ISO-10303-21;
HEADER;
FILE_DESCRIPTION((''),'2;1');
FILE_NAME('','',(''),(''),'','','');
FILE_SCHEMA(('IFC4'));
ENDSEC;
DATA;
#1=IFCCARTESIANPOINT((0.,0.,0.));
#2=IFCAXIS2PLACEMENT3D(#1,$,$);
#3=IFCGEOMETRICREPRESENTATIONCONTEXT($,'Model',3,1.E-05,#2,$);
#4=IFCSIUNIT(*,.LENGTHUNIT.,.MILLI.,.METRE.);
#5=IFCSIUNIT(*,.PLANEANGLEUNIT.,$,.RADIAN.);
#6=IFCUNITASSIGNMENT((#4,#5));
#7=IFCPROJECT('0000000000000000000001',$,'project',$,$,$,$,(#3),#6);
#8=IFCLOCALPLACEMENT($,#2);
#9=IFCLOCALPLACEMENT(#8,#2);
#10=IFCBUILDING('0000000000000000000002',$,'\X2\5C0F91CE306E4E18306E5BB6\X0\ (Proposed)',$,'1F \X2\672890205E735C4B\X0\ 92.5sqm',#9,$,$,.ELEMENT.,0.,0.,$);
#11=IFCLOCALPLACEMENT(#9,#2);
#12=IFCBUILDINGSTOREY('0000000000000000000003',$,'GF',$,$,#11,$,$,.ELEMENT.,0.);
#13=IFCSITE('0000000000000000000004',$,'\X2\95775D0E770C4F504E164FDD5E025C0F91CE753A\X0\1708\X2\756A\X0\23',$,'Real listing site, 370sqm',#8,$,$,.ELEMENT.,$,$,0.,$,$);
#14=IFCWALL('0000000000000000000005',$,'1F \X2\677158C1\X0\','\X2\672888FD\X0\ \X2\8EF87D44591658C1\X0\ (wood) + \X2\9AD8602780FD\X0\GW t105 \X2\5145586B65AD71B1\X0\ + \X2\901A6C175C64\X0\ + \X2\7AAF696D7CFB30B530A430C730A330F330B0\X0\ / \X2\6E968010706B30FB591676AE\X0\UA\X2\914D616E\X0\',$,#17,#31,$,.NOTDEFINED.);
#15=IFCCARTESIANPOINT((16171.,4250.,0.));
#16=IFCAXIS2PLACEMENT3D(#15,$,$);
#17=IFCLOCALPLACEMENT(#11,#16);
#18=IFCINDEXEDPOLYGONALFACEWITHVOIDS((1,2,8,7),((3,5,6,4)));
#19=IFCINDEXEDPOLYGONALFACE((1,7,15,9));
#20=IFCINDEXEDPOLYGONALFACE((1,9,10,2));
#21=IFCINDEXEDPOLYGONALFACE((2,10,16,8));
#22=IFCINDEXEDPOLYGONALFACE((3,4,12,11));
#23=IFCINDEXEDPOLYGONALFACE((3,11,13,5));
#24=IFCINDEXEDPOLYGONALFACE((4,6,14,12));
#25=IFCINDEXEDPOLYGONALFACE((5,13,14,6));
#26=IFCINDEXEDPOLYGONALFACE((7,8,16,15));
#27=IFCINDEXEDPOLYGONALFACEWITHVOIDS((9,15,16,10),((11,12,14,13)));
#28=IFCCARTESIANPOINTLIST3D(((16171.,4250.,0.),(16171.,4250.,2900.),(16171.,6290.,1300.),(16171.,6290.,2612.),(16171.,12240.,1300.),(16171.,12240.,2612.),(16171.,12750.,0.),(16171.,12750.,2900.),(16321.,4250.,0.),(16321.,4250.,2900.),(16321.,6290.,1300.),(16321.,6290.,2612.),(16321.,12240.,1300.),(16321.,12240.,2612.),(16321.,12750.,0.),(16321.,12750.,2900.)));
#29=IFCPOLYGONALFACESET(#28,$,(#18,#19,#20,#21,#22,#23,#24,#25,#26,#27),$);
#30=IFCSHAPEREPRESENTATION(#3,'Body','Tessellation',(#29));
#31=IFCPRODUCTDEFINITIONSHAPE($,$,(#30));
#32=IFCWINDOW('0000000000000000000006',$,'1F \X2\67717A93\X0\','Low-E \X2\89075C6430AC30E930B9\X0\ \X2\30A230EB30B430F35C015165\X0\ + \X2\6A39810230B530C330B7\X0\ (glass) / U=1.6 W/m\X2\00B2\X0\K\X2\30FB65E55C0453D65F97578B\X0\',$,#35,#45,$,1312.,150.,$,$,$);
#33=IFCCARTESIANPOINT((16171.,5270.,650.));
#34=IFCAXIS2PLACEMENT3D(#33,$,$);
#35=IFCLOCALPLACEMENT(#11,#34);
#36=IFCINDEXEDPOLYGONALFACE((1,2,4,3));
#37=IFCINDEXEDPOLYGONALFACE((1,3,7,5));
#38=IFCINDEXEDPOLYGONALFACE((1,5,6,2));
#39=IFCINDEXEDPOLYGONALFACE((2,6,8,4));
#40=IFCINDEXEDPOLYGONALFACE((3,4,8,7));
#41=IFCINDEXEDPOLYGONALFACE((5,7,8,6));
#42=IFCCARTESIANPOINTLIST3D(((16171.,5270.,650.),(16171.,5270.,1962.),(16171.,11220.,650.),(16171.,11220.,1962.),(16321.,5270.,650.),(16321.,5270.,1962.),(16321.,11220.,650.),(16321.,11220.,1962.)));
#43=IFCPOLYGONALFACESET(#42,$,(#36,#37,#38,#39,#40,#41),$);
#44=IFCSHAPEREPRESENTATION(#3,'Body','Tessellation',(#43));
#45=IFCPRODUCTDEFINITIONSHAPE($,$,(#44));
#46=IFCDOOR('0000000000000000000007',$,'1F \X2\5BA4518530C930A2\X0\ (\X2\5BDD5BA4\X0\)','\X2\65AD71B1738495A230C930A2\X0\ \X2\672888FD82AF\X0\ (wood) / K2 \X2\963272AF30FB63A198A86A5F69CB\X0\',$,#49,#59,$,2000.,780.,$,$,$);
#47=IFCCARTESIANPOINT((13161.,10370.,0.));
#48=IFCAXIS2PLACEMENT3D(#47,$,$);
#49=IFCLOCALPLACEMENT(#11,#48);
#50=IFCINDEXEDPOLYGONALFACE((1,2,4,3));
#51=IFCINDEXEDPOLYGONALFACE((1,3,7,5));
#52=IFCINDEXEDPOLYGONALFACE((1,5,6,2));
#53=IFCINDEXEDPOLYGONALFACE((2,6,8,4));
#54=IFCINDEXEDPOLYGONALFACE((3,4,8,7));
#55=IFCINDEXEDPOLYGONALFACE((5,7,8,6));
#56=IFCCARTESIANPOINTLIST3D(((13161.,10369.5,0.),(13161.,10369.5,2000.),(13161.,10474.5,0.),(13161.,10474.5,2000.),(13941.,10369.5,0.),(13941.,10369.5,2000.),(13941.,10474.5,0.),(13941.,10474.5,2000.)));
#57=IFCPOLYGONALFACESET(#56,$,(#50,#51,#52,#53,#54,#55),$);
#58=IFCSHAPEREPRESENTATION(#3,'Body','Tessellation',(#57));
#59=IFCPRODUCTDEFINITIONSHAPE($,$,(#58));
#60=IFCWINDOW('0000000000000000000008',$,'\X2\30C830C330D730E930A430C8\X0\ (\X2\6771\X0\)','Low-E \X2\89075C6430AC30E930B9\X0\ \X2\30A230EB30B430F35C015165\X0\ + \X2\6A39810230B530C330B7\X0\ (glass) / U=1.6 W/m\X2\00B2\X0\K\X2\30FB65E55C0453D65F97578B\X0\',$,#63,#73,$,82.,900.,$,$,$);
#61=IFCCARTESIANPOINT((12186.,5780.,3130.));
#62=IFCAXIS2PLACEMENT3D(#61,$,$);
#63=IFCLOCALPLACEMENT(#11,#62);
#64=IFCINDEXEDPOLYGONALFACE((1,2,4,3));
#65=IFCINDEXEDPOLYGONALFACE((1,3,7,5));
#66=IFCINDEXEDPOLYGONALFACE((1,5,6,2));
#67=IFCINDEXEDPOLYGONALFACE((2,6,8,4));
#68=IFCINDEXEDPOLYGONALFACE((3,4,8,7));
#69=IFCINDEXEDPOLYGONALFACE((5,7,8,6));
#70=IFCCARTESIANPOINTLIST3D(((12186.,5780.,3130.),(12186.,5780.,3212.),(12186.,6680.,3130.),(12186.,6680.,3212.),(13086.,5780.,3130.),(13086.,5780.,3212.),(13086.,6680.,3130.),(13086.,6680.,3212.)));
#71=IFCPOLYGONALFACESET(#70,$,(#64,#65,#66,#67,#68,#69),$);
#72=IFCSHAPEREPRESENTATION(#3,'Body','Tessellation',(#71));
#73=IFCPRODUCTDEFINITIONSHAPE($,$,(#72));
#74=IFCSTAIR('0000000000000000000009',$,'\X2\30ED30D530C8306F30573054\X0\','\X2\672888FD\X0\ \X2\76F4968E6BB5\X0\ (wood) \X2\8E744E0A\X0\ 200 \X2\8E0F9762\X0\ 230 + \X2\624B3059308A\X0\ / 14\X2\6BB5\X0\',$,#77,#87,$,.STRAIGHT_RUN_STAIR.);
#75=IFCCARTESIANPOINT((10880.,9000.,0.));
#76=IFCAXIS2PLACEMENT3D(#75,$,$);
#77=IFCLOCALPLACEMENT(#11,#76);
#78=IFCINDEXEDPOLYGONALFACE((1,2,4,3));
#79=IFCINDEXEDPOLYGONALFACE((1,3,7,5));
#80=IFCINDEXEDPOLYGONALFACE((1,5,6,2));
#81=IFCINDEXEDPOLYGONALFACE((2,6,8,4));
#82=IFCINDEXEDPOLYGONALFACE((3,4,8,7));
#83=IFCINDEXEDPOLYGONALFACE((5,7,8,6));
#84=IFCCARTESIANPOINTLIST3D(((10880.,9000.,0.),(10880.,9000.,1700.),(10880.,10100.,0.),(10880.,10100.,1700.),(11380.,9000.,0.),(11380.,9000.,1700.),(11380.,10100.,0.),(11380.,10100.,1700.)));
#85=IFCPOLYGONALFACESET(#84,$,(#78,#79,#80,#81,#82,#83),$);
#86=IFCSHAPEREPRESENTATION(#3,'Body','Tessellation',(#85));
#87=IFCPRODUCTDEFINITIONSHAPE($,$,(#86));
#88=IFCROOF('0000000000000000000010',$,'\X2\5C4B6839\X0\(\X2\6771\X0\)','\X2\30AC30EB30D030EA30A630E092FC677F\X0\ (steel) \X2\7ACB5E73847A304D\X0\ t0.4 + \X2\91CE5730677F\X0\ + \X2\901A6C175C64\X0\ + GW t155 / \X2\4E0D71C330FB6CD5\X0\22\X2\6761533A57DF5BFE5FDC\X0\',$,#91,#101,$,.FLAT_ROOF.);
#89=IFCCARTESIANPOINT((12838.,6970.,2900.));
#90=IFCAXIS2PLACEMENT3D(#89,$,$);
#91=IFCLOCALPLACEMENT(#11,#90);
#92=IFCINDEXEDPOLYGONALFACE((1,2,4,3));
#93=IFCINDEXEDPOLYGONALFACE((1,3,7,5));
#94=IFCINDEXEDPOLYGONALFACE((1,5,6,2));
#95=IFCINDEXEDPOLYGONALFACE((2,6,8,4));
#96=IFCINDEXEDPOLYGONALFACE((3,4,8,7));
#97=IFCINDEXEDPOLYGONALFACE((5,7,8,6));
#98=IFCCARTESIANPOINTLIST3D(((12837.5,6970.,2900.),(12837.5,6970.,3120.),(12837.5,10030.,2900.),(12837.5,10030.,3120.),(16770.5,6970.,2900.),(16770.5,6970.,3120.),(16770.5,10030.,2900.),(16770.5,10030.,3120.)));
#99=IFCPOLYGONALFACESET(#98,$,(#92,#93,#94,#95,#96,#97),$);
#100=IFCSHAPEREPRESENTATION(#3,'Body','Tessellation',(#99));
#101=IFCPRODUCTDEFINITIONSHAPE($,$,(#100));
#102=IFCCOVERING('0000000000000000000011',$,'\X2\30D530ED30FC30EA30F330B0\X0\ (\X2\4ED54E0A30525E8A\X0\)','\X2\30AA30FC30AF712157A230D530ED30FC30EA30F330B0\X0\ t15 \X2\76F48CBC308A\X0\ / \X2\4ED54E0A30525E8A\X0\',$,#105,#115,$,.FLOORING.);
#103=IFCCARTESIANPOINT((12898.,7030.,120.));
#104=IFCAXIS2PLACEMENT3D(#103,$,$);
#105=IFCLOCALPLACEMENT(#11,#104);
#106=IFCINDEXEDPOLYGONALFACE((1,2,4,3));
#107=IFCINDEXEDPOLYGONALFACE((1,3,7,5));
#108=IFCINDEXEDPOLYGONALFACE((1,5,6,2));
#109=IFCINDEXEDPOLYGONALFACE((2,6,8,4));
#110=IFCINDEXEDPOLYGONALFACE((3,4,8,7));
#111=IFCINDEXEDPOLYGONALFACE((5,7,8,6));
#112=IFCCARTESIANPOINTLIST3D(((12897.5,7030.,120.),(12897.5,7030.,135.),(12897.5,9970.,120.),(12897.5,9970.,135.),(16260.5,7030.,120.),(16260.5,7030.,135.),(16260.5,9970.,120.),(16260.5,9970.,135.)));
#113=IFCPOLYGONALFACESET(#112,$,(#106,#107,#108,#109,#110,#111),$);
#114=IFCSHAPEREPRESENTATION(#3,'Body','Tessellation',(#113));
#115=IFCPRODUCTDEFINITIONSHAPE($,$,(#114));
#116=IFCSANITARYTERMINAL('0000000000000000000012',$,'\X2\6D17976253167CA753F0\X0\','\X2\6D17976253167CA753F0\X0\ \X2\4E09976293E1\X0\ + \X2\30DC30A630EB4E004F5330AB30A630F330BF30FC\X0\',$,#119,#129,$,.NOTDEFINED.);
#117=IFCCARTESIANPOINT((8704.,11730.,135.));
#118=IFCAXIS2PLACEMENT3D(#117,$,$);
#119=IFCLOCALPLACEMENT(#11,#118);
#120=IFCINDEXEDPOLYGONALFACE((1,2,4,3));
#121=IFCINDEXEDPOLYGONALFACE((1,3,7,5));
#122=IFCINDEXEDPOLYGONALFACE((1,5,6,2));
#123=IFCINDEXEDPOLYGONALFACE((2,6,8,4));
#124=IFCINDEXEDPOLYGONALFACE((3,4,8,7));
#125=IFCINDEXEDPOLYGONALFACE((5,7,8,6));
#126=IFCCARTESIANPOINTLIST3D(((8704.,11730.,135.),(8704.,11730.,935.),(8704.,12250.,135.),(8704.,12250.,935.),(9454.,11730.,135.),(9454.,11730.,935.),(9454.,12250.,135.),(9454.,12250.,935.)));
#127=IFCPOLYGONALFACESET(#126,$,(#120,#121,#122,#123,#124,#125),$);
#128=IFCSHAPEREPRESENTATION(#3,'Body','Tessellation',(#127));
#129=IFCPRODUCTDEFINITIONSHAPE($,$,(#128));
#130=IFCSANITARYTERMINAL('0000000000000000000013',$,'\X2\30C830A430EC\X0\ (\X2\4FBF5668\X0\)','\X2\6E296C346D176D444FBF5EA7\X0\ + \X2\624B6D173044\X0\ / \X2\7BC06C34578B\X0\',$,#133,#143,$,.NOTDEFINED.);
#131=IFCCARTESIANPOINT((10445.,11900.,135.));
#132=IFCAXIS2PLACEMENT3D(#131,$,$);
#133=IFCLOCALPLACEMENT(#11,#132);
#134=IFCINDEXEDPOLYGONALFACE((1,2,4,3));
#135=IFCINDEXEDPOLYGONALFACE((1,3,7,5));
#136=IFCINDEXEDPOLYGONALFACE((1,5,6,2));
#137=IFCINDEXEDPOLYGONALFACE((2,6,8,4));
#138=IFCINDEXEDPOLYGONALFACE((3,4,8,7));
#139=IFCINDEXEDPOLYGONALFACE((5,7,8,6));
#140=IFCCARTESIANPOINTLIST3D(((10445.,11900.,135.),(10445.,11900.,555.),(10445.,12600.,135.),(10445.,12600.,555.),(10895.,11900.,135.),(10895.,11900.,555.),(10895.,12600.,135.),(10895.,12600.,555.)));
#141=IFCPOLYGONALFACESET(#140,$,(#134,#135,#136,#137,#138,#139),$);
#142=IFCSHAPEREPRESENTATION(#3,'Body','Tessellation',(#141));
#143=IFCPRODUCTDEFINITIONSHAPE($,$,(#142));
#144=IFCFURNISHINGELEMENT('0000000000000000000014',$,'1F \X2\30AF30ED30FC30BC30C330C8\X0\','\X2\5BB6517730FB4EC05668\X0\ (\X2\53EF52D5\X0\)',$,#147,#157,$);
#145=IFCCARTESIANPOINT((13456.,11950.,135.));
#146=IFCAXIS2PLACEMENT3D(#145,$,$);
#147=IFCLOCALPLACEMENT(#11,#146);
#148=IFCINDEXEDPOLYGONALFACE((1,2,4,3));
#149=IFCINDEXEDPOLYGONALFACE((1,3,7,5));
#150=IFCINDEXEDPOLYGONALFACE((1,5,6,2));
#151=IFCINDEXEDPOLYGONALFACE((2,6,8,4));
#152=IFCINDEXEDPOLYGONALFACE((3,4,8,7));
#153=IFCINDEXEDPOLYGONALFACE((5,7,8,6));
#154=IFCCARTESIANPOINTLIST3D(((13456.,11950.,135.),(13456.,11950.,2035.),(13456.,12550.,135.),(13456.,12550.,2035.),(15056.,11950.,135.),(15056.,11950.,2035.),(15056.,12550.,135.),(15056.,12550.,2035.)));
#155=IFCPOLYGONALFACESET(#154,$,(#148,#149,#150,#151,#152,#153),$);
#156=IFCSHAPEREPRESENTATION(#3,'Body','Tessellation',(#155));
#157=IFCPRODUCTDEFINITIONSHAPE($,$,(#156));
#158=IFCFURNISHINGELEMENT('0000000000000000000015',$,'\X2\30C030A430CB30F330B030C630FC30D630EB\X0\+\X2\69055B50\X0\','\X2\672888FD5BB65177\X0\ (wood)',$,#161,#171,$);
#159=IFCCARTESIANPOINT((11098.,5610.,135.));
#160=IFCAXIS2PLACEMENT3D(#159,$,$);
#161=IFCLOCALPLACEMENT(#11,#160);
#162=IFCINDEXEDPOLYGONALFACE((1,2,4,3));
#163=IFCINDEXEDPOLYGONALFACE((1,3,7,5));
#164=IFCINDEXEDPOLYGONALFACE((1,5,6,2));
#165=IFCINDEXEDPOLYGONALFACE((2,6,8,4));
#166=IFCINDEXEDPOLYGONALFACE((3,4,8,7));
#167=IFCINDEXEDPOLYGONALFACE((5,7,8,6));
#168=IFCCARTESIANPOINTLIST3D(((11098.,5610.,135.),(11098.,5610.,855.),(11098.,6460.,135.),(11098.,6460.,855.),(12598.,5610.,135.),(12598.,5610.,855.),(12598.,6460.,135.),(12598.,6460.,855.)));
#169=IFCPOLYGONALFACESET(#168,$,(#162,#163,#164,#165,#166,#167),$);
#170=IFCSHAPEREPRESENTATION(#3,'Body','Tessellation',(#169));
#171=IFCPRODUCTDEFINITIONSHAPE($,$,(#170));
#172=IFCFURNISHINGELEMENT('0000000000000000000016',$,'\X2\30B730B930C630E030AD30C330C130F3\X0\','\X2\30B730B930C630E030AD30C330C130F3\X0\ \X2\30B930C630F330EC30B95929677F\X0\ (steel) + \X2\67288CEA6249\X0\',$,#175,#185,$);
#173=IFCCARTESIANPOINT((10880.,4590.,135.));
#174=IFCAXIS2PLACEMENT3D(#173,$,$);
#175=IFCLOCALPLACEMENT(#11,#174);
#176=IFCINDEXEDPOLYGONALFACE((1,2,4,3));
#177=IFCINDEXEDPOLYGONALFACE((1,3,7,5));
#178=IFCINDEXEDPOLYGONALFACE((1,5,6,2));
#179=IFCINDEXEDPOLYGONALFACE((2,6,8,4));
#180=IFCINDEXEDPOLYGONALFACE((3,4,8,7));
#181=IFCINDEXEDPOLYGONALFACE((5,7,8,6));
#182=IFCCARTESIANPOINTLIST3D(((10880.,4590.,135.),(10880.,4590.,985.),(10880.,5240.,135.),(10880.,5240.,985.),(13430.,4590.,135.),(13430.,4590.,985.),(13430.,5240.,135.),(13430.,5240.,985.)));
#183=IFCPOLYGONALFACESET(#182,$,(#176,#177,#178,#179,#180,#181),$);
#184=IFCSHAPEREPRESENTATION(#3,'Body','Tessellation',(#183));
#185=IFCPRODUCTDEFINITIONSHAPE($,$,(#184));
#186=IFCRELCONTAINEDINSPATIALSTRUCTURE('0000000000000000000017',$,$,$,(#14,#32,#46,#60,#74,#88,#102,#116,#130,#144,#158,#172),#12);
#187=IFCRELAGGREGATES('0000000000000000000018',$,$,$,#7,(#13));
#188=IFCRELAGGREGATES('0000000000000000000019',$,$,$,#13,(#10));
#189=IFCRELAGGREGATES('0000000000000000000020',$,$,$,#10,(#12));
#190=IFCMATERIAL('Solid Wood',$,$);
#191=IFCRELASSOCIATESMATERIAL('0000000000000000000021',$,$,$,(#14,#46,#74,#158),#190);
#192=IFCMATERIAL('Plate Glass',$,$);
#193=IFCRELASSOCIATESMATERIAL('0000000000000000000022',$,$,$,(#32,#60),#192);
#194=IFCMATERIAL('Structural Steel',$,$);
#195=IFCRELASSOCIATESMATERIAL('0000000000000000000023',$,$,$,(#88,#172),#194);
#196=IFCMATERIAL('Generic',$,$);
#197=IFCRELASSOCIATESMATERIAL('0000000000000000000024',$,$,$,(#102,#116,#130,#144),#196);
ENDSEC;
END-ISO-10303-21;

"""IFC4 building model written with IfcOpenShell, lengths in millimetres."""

from ifc_helpers import new_model, si_unit, frame, frame_2d, origin, place, context, project, spatial, rectangle, extrude, material, element, fill, save


model = new_model("IFC4")

# Units and contexts
model_context = context("Model", 3, precision=1e-05, world=origin())
ifc_project = project(units=[si_unit("LENGTHUNIT", "METRE", prefix="MILLI"), si_unit("PLANEANGLEUNIT", "RADIAN")], contexts=[model_context])

# Site, building, storey
site_placement = place(None, origin())
site = spatial("IfcSite", under=ifc_project, at=site_placement, Name="長崎県佐世保市小野町1708番23", ObjectType="Real listing site, 370sqm", CompositionType="ELEMENT", RefElevation=0.0)
building_placement = place(site_placement, origin())
building = spatial("IfcBuilding", under=site, at=building_placement, Name="小野の丘の家 (Proposed)", ObjectType="1F 木造平屋 92.5sqm", CompositionType="ELEMENT", ElevationOfRefHeight=0.0, ElevationOfTerrain=0.0)
storey_placement = place(building_placement, origin())
storey = spatial("IfcBuildingStorey", under=building, at=storey_placement, Name="GF", CompositionType="ELEMENT", Elevation=0.0)

# Shared definitions
ifc_material_1 = material(Name="Solid Wood")

# Wall, opening, window
wall_1_placement = place(storey_placement, frame((16171.0, 4250.0, 0.0)))
wall_1 = element("IfcWall", 1, at=wall_1_placement, inside=storey, material=ifc_material_1, Name="1F 東壁", Description="木製 軸組外壁 (wood) + 高性能GW t105 充填断熱 + 通気層 + 窯業系サイディング / 準耐火・外皮UA配慮", PredefinedType="NOTDEFINED", context=model_context, shape_type="SweptSolid", body=[
    extrude(rectangle(XDim=150.0, YDim=8500.0, at=frame_2d((75.0, 4250.0))), frame((16171.0, 4250.0, 0.0)), (0.0, 0.0, 1.0), 2900.0),
])
opening_1_placement = place(storey_placement, frame((16171.0, 5270.0, 650.0)))
opening_1 = element("IfcOpeningElement", 2, at=opening_1_placement, cuts=wall_1, PredefinedType="NOTDEFINED", context=model_context, shape_type="SweptSolid", body=[
    extrude(rectangle(XDim=150.0, YDim=5950.0, at=frame_2d((75.0, 2975.0))), frame((16171.0, 5270.0, 650.0)), (0.0, 0.0, 1.0), 1312.0),
])
ifc_material_2 = material(Name="Plate Glass")
window_1_placement = place(storey_placement, frame((16171.0, 5270.0, 650.0)))
window_1 = element("IfcWindow", 3, at=window_1_placement, inside=storey, material=ifc_material_2, Name="1F 東窓", Description="Low-E 複層ガラス アルゴン封入 + 樹脂サッシ (glass) / U=1.6 W/m²K・日射取得型", OverallHeight=1312.0, OverallWidth=150.0, context=model_context, shape_type="SweptSolid", body=[
    extrude(rectangle(XDim=150.0, YDim=5950.0, at=frame_2d((75.0, 2975.0))), frame((16171.0, 5270.0, 650.0)), (0.0, 0.0, 1.0), 1312.0),
])
fill(opening_1, window_1)

# Door
door_placement = place(storey_placement, frame((13161.0, 10370.0, 0.0)))
element("IfcDoor", 4, at=door_placement, inside=storey, material=ifc_material_1, Name="1F 室内ドア (寝室)", Description="断熱玄関ドア 木製芯 (wood) / K2 防犯・採風機構", OverallHeight=2000.0, OverallWidth=780.0, context=model_context, shape_type="SweptSolid", body=[
    extrude(rectangle(XDim=780.0, YDim=105.0, at=frame_2d((390.0, 52.0))), frame((13161.0, 10370.0, 0.0)), (0.0, 0.0, 1.0), 2000.0),
])

# Window
window_2_placement = place(storey_placement, frame((12186.0, 5780.0, 3130.0)))
element("IfcWindow", 5, at=window_2_placement, inside=storey, material=ifc_material_2, Name="トップライト (東)", Description="Low-E 複層ガラス アルゴン封入 + 樹脂サッシ (glass) / U=1.6 W/m²K・日射取得型", OverallHeight=82.0, OverallWidth=900.0, context=model_context, shape_type="SweptSolid", body=[
    extrude(rectangle(XDim=900.0, YDim=900.0, at=frame_2d((450.0, 450.0))), frame((12186.0, 5780.0, 3130.0)), (0.0, 0.0, 1.0), 82.0),
])

# Stair
stair_placement = place(storey_placement, frame((10880.0, 9000.0, 0.0)))
element("IfcStair", 6, at=stair_placement, inside=storey, material=ifc_material_1, Name="ロフトはしご", Description="木製 直階段 (wood) 蹴上 200 踏面 230 + 手すり / 14段", PredefinedType="STRAIGHT_RUN_STAIR", context=model_context, shape_type="SweptSolid", body=[
    extrude(rectangle(XDim=500.0, YDim=1100.0, at=frame_2d((250.0, 550.0))), frame((10880.0, 9000.0, 0.0)), (0.0, 0.0, 1.0), 1700.0),
])

# Roof
ifc_material_3 = material(Name="Structural Steel")
roof_placement = place(storey_placement, frame((12838.0, 6970.0, 2900.0)))
element("IfcRoof", 7, at=roof_placement, inside=storey, material=ifc_material_3, Name="屋根(東)", Description="ガルバリウム鋼板 (steel) 立平葺き t0.4 + 野地板 + 通気層 + GW t155 / 不燃・法22条区域対応", PredefinedType="FLAT_ROOF", context=model_context, shape_type="SweptSolid", body=[
    extrude(rectangle(XDim=3933.0, YDim=3060.0, at=frame_2d((1966.0, 1530.0))), frame((12838.0, 6970.0, 2900.0)), (0.0, 0.0, 1.0), 220.0),
])

# Covering
ifc_material_4 = material(Name="Generic")
covering_placement = place(storey_placement, frame((12898.0, 7030.0, 120.0)))
element("IfcCovering", 8, at=covering_placement, inside=storey, material=ifc_material_4, Name="フローリング (仕上げ床)", Description="オーク無垢フローリング t15 直貼り / 仕上げ床", PredefinedType="FLOORING", context=model_context, shape_type="SweptSolid", body=[
    extrude(rectangle(XDim=3363.0, YDim=2940.0, at=frame_2d((1681.0, 1470.0))), frame((12898.0, 7030.0, 120.0)), (0.0, 0.0, 1.0), 15.0),
])

# Sanitary terminals
sanitary_terminal_1_placement = place(storey_placement, frame((8704.0, 11730.0, 135.0)))
element("IfcSanitaryTerminal", 9, at=sanitary_terminal_1_placement, inside=storey, material=ifc_material_4, Name="洗面化粧台", Description="洗面化粧台 三面鏡 + ボウル一体カウンター", PredefinedType="NOTDEFINED", context=model_context, shape_type="SweptSolid", body=[
    extrude(rectangle(XDim=750.0, YDim=520.0, at=frame_2d((375.0, 260.0))), frame((8704.0, 11730.0, 135.0)), (0.0, 0.0, 1.0), 800.0),
])
sanitary_terminal_2_placement = place(storey_placement, frame((10445.0, 11900.0, 135.0)))
element("IfcSanitaryTerminal", 10, at=sanitary_terminal_2_placement, inside=storey, material=ifc_material_4, Name="トイレ (便器)", Description="温水洗浄便座 + 手洗い / 節水型", PredefinedType="NOTDEFINED", context=model_context, shape_type="SweptSolid", body=[
    extrude(rectangle(XDim=450.0, YDim=700.0, at=frame_2d((225.0, 350.0))), frame((10445.0, 11900.0, 135.0)), (0.0, 0.0, 1.0), 420.0),
])

# Furnishing elements
furnishing_1_placement = place(storey_placement, frame((13456.0, 11950.0, 135.0)))
element("IfcFurnishingElement", 11, at=furnishing_1_placement, inside=storey, material=ifc_material_4, Name="1F クローゼット", Description="家具・什器 (可動)", context=model_context, shape_type="SweptSolid", body=[
    extrude(rectangle(XDim=1600.0, YDim=600.0, at=frame_2d((800.0, 300.0))), frame((13456.0, 11950.0, 135.0)), (0.0, 0.0, 1.0), 1900.0),
])
furnishing_2_placement = place(storey_placement, frame((11098.0, 5610.0, 135.0)))
element("IfcFurnishingElement", 12, at=furnishing_2_placement, inside=storey, material=ifc_material_1, Name="ダイニングテーブル+椅子", Description="木製家具 (wood)", context=model_context, shape_type="SweptSolid", body=[
    extrude(rectangle(XDim=1500.0, YDim=850.0, at=frame_2d((750.0, 425.0))), frame((11098.0, 5610.0, 135.0)), (0.0, 0.0, 1.0), 720.0),
])
furnishing_3_placement = place(storey_placement, frame((10880.0, 4590.0, 135.0)))
element("IfcFurnishingElement", 13, at=furnishing_3_placement, inside=storey, material=ifc_material_3, Name="システムキッチン", Description="システムキッチン ステンレス天板 (steel) + 木質扉", context=model_context, shape_type="SweptSolid", body=[
    extrude(rectangle(XDim=2550.0, YDim=650.0, at=frame_2d((1275.0, 325.0))), frame((10880.0, 4590.0, 135.0)), (0.0, 0.0, 1.0), 850.0),
])

save(model, "model.ifc")
